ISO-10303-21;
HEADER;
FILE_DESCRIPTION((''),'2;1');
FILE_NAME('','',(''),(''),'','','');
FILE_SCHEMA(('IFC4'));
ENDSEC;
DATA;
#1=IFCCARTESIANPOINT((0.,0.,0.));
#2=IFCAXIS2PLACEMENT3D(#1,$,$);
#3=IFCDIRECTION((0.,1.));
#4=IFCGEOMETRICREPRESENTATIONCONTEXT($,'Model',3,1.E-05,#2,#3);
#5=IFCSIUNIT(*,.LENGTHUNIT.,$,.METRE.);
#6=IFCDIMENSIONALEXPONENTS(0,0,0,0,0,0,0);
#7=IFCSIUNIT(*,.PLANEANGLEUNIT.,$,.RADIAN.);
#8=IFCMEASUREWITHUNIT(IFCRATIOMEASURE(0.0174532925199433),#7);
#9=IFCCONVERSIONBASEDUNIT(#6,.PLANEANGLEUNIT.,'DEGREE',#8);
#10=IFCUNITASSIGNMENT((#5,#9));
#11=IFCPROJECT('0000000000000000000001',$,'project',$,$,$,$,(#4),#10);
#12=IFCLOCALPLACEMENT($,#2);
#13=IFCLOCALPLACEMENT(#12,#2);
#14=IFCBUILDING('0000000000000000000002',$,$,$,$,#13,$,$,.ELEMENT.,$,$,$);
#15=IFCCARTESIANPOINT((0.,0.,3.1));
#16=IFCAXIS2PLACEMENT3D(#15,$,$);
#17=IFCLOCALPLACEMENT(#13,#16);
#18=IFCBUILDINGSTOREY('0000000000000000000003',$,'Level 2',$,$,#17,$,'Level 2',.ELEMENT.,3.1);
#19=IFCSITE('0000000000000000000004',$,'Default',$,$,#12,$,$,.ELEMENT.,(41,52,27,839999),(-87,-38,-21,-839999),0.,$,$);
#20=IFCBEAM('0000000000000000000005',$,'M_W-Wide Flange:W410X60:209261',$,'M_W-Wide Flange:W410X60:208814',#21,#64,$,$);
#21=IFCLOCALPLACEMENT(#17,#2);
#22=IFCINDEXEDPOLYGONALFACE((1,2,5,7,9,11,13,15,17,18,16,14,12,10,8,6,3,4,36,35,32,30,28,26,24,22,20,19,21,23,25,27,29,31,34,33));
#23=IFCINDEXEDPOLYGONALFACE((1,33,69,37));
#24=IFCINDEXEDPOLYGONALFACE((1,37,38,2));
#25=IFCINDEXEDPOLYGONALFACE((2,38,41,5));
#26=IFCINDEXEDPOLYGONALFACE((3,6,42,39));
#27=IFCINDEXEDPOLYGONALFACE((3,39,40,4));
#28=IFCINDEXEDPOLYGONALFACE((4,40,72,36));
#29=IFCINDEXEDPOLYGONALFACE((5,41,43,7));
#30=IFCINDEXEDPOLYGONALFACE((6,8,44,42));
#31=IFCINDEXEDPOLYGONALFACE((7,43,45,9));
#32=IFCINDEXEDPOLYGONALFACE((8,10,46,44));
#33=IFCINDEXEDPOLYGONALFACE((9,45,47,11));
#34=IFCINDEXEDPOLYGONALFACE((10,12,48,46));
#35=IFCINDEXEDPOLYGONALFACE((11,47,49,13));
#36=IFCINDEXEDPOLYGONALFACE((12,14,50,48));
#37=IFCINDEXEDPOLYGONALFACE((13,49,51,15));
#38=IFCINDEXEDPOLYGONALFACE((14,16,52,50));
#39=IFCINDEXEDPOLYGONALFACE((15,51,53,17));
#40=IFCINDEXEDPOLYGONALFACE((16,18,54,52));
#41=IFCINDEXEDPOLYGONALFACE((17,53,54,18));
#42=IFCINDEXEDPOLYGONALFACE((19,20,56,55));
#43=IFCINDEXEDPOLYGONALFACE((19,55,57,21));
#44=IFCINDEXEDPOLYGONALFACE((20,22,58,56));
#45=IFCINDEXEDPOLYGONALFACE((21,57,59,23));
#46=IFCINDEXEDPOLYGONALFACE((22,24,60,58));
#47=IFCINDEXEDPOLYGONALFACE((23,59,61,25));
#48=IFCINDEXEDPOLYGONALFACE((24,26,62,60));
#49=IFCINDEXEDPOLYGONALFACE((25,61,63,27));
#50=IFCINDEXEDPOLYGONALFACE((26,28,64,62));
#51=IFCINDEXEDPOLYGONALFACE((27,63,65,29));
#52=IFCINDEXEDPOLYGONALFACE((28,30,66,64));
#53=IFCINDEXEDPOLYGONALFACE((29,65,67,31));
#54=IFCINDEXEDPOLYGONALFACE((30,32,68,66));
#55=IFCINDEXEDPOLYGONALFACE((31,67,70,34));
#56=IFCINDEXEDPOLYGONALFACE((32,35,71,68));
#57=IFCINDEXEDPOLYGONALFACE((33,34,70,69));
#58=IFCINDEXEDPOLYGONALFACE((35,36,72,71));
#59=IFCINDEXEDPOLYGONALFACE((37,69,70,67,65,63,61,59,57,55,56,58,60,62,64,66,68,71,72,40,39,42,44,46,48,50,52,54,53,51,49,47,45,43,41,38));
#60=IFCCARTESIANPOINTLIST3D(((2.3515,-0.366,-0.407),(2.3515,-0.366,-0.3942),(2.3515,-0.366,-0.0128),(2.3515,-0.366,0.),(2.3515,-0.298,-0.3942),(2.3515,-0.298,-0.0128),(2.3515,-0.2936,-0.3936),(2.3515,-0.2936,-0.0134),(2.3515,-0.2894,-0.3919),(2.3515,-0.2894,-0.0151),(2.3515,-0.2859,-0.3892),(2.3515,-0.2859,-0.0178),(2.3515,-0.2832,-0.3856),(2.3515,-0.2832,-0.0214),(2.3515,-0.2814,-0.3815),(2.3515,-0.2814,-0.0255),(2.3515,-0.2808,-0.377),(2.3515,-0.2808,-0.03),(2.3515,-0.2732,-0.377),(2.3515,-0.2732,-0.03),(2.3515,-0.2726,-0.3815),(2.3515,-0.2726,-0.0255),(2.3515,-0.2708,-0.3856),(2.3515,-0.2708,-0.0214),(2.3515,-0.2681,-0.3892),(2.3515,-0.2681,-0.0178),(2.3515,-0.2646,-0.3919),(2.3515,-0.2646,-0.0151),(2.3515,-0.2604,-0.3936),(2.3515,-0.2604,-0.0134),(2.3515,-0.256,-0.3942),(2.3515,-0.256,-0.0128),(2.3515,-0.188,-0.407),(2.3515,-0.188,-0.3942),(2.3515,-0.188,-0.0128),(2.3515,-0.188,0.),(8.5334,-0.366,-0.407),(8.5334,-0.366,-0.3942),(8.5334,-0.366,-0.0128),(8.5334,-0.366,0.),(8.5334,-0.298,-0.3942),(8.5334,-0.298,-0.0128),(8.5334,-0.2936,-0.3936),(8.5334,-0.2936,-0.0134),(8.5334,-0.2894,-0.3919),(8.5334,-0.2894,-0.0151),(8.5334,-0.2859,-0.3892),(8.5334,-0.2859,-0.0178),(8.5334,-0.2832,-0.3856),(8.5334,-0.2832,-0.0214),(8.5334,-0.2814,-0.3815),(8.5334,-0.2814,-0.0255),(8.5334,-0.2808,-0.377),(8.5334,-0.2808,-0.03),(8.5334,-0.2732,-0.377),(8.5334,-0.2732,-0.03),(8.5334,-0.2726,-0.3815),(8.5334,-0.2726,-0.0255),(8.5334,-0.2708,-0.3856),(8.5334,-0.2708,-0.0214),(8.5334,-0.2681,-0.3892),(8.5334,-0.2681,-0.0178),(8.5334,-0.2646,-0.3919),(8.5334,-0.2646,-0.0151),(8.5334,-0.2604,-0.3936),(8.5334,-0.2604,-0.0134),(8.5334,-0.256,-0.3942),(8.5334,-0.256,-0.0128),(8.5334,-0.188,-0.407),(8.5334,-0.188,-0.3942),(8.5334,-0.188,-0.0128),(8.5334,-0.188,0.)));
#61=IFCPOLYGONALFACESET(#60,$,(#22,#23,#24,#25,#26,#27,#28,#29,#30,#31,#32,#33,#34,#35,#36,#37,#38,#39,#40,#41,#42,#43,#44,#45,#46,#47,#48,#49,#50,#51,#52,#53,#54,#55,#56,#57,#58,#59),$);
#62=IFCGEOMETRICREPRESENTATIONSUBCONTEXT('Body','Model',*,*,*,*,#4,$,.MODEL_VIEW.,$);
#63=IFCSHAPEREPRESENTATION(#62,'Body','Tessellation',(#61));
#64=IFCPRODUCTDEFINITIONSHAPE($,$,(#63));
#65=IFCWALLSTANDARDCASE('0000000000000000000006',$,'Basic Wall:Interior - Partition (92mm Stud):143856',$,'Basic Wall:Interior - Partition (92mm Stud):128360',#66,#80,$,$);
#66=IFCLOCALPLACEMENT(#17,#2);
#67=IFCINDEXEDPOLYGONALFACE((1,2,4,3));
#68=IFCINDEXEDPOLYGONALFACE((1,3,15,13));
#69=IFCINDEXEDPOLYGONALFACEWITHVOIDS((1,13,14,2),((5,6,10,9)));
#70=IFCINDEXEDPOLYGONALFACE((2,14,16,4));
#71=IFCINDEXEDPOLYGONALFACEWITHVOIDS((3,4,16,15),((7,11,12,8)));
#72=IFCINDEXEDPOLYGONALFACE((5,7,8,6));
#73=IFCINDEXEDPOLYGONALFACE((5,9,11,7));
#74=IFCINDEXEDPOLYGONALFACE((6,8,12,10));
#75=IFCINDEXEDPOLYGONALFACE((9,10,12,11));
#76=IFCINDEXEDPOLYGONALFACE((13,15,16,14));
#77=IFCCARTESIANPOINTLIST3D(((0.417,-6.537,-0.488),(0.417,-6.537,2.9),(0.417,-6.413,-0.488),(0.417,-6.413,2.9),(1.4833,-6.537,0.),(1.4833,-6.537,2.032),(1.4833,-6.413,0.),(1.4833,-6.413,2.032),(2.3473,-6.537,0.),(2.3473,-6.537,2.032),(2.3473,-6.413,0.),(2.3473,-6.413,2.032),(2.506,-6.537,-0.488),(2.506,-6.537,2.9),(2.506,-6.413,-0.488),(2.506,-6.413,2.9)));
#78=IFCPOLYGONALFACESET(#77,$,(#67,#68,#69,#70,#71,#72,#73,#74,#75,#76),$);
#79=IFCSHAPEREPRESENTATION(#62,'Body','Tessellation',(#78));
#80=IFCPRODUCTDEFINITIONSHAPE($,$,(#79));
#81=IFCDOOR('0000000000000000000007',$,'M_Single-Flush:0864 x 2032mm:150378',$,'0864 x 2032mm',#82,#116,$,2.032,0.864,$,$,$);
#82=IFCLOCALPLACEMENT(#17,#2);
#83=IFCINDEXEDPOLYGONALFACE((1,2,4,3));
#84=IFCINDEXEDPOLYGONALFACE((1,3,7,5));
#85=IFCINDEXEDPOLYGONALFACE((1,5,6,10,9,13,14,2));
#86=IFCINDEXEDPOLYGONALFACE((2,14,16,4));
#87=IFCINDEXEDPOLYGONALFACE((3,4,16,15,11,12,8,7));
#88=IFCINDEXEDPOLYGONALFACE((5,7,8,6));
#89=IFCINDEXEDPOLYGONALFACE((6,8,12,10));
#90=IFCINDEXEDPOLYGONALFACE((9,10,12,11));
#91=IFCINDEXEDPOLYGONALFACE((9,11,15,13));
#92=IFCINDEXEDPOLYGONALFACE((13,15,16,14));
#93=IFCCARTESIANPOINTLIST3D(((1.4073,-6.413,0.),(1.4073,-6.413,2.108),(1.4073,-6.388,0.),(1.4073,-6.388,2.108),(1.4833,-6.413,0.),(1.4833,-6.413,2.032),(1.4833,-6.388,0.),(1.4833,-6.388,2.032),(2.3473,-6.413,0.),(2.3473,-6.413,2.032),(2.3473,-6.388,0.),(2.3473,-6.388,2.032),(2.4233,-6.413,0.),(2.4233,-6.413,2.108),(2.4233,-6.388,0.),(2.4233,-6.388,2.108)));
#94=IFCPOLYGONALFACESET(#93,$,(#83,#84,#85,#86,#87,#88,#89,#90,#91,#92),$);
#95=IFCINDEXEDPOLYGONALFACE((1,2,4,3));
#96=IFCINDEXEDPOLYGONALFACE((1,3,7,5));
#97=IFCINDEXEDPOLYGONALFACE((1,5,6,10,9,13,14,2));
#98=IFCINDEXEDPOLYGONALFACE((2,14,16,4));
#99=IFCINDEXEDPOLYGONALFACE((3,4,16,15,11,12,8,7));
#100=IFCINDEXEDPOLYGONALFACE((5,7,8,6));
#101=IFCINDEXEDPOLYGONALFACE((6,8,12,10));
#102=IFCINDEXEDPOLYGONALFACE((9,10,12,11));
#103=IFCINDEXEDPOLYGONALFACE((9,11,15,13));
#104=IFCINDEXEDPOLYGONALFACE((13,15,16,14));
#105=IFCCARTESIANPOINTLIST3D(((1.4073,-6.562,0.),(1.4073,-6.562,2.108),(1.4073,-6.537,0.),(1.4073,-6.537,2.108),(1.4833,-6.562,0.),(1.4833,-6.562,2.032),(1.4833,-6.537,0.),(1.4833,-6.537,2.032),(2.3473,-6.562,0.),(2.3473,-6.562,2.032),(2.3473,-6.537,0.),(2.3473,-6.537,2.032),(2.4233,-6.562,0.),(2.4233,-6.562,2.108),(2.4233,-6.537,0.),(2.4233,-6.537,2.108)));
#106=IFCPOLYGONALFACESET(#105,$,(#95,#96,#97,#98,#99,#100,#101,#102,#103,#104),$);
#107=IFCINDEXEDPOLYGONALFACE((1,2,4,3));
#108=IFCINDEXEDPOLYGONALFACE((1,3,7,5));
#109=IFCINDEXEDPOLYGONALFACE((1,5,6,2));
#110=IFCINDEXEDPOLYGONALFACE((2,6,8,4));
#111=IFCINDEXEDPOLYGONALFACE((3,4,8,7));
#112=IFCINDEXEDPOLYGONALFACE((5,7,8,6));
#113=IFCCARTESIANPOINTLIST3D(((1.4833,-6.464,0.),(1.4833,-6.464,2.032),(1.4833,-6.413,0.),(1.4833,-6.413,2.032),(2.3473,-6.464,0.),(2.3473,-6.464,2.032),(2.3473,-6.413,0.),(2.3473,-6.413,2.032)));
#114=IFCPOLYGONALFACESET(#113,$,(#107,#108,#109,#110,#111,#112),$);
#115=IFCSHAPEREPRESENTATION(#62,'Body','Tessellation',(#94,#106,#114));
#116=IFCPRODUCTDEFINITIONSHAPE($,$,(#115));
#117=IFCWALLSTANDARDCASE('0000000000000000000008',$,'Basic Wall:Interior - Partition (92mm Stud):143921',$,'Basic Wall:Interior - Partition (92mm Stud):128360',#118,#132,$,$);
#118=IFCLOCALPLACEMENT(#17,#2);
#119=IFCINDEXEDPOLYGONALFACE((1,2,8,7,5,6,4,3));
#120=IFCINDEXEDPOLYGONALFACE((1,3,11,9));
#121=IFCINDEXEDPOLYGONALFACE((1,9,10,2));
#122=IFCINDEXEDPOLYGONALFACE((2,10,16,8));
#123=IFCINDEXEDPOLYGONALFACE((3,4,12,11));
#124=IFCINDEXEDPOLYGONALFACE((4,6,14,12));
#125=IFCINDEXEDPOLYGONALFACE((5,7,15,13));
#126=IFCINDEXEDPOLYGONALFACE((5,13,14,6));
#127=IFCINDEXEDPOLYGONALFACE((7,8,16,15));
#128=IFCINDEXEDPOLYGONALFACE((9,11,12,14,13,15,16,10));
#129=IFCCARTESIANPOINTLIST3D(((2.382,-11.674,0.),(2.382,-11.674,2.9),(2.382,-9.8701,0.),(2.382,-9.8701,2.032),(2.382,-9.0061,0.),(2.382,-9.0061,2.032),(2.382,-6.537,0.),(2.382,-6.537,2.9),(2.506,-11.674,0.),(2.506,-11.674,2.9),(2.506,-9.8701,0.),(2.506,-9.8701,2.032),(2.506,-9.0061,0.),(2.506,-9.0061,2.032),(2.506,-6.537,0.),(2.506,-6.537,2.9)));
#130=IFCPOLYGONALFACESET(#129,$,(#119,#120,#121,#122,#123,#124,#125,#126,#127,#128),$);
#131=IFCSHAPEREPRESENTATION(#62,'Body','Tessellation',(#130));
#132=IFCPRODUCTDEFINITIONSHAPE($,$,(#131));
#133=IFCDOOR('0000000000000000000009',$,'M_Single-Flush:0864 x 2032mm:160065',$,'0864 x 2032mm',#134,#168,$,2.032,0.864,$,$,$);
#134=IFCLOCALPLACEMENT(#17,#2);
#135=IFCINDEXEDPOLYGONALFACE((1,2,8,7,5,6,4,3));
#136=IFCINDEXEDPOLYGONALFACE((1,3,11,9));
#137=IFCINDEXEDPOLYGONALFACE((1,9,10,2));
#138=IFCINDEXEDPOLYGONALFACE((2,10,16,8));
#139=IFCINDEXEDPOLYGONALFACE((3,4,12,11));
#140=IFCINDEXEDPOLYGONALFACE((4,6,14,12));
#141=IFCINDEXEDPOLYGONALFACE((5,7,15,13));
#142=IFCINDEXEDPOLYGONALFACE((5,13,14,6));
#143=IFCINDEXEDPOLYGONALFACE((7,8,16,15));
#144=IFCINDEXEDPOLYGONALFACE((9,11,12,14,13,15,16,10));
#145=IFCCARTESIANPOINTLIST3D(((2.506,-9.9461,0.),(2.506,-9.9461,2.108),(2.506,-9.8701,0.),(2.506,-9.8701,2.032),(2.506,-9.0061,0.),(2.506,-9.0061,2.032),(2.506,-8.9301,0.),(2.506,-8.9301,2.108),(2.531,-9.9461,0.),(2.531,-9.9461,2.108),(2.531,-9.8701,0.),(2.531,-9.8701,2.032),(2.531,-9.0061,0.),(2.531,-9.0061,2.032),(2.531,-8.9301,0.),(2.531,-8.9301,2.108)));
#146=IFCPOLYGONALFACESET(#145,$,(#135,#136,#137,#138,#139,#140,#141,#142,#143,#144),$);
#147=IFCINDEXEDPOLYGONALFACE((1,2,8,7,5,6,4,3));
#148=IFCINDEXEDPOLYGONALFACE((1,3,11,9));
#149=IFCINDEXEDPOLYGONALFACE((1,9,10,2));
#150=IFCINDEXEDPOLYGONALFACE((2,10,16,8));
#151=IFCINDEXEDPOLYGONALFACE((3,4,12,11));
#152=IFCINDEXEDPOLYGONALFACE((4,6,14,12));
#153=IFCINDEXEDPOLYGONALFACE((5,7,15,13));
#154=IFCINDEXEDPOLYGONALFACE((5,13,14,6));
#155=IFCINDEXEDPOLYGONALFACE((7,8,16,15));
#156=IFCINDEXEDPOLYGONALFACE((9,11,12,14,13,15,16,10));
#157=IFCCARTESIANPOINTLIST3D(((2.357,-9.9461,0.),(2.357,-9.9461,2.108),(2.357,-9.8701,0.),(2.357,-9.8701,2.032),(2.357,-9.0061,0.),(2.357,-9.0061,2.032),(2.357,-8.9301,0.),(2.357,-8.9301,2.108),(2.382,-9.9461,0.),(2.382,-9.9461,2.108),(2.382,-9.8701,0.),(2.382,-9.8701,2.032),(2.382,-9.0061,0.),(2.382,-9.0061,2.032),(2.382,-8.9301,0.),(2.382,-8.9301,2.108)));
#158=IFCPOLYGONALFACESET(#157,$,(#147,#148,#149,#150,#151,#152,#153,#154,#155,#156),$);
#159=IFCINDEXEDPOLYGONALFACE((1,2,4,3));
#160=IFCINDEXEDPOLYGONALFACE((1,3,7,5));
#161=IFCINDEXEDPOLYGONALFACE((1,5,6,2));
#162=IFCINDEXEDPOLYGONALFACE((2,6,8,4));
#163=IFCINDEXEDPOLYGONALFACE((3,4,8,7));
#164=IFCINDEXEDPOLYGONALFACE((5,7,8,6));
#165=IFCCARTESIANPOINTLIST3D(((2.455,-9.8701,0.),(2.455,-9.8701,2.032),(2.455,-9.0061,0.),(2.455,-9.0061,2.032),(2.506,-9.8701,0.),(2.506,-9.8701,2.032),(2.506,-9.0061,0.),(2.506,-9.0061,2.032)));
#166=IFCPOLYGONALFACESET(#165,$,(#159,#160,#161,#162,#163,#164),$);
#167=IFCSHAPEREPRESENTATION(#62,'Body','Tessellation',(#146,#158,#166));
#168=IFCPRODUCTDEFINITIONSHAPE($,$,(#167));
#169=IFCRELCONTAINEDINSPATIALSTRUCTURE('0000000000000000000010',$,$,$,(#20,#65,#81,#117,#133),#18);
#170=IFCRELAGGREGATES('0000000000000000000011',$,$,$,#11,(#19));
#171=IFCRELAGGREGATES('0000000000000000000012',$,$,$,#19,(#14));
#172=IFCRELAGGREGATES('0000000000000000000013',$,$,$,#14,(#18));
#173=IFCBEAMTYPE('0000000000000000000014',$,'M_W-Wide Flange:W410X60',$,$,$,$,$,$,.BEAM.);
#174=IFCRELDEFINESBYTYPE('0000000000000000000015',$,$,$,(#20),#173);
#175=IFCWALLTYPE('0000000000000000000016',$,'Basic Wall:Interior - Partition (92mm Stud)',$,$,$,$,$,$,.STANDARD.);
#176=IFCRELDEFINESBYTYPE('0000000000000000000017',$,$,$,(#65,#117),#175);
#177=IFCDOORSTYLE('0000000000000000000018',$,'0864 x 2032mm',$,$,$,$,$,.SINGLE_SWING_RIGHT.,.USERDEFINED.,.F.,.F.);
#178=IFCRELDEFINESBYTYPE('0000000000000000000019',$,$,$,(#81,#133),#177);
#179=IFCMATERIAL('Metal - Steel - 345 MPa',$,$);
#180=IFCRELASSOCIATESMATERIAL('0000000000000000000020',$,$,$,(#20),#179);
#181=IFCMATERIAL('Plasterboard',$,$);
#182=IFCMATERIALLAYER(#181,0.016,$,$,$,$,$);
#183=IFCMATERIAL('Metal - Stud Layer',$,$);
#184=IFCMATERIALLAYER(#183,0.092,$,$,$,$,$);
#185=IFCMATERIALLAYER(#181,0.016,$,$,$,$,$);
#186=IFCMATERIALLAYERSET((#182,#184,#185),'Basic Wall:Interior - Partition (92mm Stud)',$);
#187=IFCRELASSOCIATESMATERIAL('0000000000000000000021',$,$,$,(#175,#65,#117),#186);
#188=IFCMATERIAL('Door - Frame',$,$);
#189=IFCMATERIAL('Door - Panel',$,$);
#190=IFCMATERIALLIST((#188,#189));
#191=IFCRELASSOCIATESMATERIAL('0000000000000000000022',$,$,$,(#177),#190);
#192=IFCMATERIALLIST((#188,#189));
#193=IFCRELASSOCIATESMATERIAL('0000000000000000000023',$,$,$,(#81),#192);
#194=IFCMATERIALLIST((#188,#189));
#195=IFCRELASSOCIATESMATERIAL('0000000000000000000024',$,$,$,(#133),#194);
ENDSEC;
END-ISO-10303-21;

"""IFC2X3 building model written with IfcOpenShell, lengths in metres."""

from ifc_helpers import new_model, entity, si_unit, converted_unit, direction, frame, frame_2d, origin, origin_2d_with_axis, place, context, subcontext, project, spatial, polyline, rectangle, i_section, outline, extrude, source, transform, mapped, material, material_list, layer, layer_set, layer_usage, type_object, type_shapes, element, fill, save


model = new_model("IFC2X3")

# Units and contexts
model_context = context("Model", 3, precision=1e-05, world=origin(), true_north=direction((0.0, 1.0)))
body_context = subcontext(model_context, "Body", "Model", "MODEL_VIEW")
ifc_project = project(units=[si_unit("LENGTHUNIT", "METRE"), converted_unit("PLANEANGLEUNIT", "DEGREE", entity("IfcRatioMeasure", 0.0174532925199433), si_unit("PLANEANGLEUNIT", "RADIAN"), dimensions=[0, 0, 0, 0, 0, 0, 0])], contexts=[model_context])

# Site, building, storey
site_placement = place(None, origin())
site = spatial("IfcSite", under=ifc_project, at=site_placement, Name="Default", CompositionType="ELEMENT", RefLatitude=(41, 52, 27, 839999), RefLongitude=(-87, -38, -21, -839999), RefElevation=0.0)
building_placement = place(site_placement, origin())
building = spatial("IfcBuilding", under=site, at=building_placement, CompositionType="ELEMENT")
storey_placement = place(building_placement, frame((0.0, 0.0, 3.1)))
storey = spatial("IfcBuildingStorey", under=building, at=storey_placement, Name="Level 2", LongName="Level 2", CompositionType="ELEMENT", Elevation=3.1)

# Beam
ifc_material_1 = material(Name="Metal - Steel - 345 MPa")
beam_type = type_object("IfcBeamType", Name="M_W-Wide Flange:W410X60", PredefinedType="BEAM")
beam_placement = place(storey_placement, frame((8.5334, -0.277, 0.0), z_axis=(0.0, 0.0, 1.0), x_axis=(-1.0, 0.0, 0.0)))
element("IfcBeam", 1, at=beam_placement, inside=storey, type_object=beam_type, material=ifc_material_1, Name="M_W-Wide Flange:W410X60:209261", ObjectType="M_W-Wide Flange:W410X60:208814", context=body_context, shape_type="SweptSolid", body=[
    extrude(i_section(OverallWidth=0.178, OverallDepth=0.407, WebThickness=0.0077, FlangeThickness=0.0128, FilletRadius=0.0172, at=frame_2d((0.0, 0.0), x_axis=(0.0, 1.0))), frame((0.0, 0.0, -0.2035), z_axis=(1.0, 0.0, 0.0), x_axis=(0.0, 0.0, -1.0)), (0.0, 0.0, 1.0), 6.1819),
])

# Shared definitions
ifc_material_2 = material(Name="Metal - Stud Layer")
ifc_material_3 = material(Name="Plasterboard")

# Walls, openings, doors
ifc_layer_1 = layer(ifc_material_3, 0.016)
ifc_layer_2 = layer(ifc_material_2, 0.092)
ifc_layer_3 = layer(ifc_material_3, 0.016)
ifc_layer_set_1 = layer_set([ifc_layer_1, ifc_layer_2, ifc_layer_3], Name="Basic Wall:Interior - Partition (92mm Stud)")
ifc_layer_usage_1 = layer_usage(ifc_layer_set_1, "AXIS2", "NEGATIVE", 0.062)
wall_type_1 = type_object("IfcWallType", Name="Basic Wall:Interior - Partition (92mm Stud)", PredefinedType="STANDARD", material=ifc_layer_set_1)
wall_1_placement = place(storey_placement, frame((0.417, -6.475, -0.488)))
wall_1 = element("IfcWallStandardCase", 2, at=wall_1_placement, inside=storey, type_object=wall_type_1, material=ifc_layer_usage_1, Name="Basic Wall:Interior - Partition (92mm Stud):143856", ObjectType="Basic Wall:Interior - Partition (92mm Stud):128360", context=body_context, shape_type="SweptSolid", body=[
    extrude(rectangle(XDim=2.089, YDim=0.124, at=frame_2d((1.0445, 0.0), x_axis=(-1.0, 0.0))), origin(), (0.0, 0.0, 1.0), 3.388),
])
opening_1_placement = place(wall_1_placement, frame((1.0663, -0.062, 0.488)))
opening_1 = element("IfcOpeningElement", 3, at=opening_1_placement, cuts=wall_1, ObjectType="Opening", context=body_context, shape_type="SweptSolid", body=[
    extrude(rectangle(XDim=0.864, YDim=2.032, at=frame_2d((1.016, 0.432), x_axis=(0.0, 1.0))), frame((0.0, 0.0, 0.0), z_axis=(0.0, 1.0, 0.0), x_axis=(0.0, 0.0, 1.0)), (0.0, 0.0, 1.0), 0.124),
])
ifc_material_4 = material(Name="Door - Frame")
ifc_material_5 = material(Name="Door - Panel")
ifc_material_list_1 = material_list([ifc_material_4, ifc_material_5])
ifc_material_list_2 = material_list([ifc_material_4, ifc_material_5])
door_style_1 = type_object("IfcDoorStyle", Name="0864 x 2032mm", ConstructionType="USERDEFINED", OperationType="SINGLE_SWING_RIGHT", ParameterTakesPrecedence=False, Sizeable=False, material=ifc_material_list_2)
shared_shape_1 = source(origin(), body_context, "Body", "SweptSolid", [
    extrude(outline(polyline([(-0.508, -1.073), (0.508, -1.073), (0.508, 1.035), (0.432, 1.035), (0.432, -0.997), (-0.432, -0.997), (-0.432, 1.035), (-0.508, 1.035), (-0.508, -1.073)])), frame((0.432, 0.124, 1.035), z_axis=(0.0, 1.0, 0.0), x_axis=(1.0, 0.0, 0.0)), (0.0, 0.0, 1.0), 0.025),
    extrude(outline(polyline([(-1.073, -0.508), (1.035, -0.508), (1.035, -0.432), (-0.997, -0.432), (-0.997, 0.432), (1.035, 0.432), (1.035, 0.508), (-1.073, 0.508), (-1.073, -0.508)])), frame((0.432, -0.025, 1.035), z_axis=(0.0, 1.0, 0.0), x_axis=(0.0, 0.0, -1.0)), (0.0, 0.0, 1.0), 0.025),
    extrude(rectangle(XDim=0.051, YDim=0.864, at=origin_2d_with_axis()), frame((0.432, 0.0985, 0.0), z_axis=(0.0, 0.0, 1.0), x_axis=(0.0, 1.0, 0.0)), (0.0, 0.0, 1.0), 2.032),
])
type_shapes(door_style_1, [shared_shape_1])
door_1_placement = place(opening_1_placement, origin())
door_1 = element("IfcDoor", 4, at=door_1_placement, inside=storey, type_object=door_style_1, material=ifc_material_list_1, Name="M_Single-Flush:0864 x 2032mm:150378", ObjectType="0864 x 2032mm", OverallHeight=2.032, OverallWidth=0.864, context=body_context, shape_type="MappedRepresentation", body=[
    mapped(shared_shape_1, transform((0.0, 0.0, 0.0), scale=1.0)),
])
fill(opening_1, door_1)
ifc_layer_usage_2 = layer_usage(ifc_layer_set_1, "AXIS2", "NEGATIVE", 0.062)
wall_2_placement = place(storey_placement, frame((2.444, -6.537, 0.0), z_axis=(0.0, 0.0, 1.0), x_axis=(0.0, -1.0, 0.0)))
wall_2 = element("IfcWallStandardCase", 5, at=wall_2_placement, inside=storey, type_object=wall_type_1, material=ifc_layer_usage_2, Name="Basic Wall:Interior - Partition (92mm Stud):143921", ObjectType="Basic Wall:Interior - Partition (92mm Stud):128360", context=body_context, shape_type="SweptSolid", body=[
    extrude(rectangle(XDim=5.137, YDim=0.124, at=frame_2d((2.5685, 0.0), x_axis=(-1.0, 0.0))), origin(), (0.0, 0.0, 1.0), 2.9),
])
opening_2_placement = place(wall_2_placement, frame((2.4691, -0.062, 0.0)))
opening_2 = element("IfcOpeningElement", 6, at=opening_2_placement, cuts=wall_2, ObjectType="Opening", context=body_context, shape_type="SweptSolid", body=[
    extrude(rectangle(XDim=0.864, YDim=2.032, at=frame_2d((1.016, 0.432), x_axis=(0.0, 1.0))), frame((0.0, 0.0, 0.0), z_axis=(0.0, 1.0, 0.0), x_axis=(0.0, 0.0, 1.0)), (0.0, 0.0, 1.0), 0.124),
])
ifc_material_list_3 = material_list([ifc_material_4, ifc_material_5])
door_2_placement = place(opening_2_placement, origin())
door_2 = element("IfcDoor", 7, at=door_2_placement, inside=storey, type_object=door_style_1, material=ifc_material_list_3, Name="M_Single-Flush:0864 x 2032mm:160065", ObjectType="0864 x 2032mm", OverallHeight=2.032, OverallWidth=0.864, context=body_context, shape_type="MappedRepresentation", body=[
    mapped(shared_shape_1, transform((0.0, 0.0, 0.0), scale=1.0)),
])
fill(opening_2, door_2)

save(model, "model.ifc")
